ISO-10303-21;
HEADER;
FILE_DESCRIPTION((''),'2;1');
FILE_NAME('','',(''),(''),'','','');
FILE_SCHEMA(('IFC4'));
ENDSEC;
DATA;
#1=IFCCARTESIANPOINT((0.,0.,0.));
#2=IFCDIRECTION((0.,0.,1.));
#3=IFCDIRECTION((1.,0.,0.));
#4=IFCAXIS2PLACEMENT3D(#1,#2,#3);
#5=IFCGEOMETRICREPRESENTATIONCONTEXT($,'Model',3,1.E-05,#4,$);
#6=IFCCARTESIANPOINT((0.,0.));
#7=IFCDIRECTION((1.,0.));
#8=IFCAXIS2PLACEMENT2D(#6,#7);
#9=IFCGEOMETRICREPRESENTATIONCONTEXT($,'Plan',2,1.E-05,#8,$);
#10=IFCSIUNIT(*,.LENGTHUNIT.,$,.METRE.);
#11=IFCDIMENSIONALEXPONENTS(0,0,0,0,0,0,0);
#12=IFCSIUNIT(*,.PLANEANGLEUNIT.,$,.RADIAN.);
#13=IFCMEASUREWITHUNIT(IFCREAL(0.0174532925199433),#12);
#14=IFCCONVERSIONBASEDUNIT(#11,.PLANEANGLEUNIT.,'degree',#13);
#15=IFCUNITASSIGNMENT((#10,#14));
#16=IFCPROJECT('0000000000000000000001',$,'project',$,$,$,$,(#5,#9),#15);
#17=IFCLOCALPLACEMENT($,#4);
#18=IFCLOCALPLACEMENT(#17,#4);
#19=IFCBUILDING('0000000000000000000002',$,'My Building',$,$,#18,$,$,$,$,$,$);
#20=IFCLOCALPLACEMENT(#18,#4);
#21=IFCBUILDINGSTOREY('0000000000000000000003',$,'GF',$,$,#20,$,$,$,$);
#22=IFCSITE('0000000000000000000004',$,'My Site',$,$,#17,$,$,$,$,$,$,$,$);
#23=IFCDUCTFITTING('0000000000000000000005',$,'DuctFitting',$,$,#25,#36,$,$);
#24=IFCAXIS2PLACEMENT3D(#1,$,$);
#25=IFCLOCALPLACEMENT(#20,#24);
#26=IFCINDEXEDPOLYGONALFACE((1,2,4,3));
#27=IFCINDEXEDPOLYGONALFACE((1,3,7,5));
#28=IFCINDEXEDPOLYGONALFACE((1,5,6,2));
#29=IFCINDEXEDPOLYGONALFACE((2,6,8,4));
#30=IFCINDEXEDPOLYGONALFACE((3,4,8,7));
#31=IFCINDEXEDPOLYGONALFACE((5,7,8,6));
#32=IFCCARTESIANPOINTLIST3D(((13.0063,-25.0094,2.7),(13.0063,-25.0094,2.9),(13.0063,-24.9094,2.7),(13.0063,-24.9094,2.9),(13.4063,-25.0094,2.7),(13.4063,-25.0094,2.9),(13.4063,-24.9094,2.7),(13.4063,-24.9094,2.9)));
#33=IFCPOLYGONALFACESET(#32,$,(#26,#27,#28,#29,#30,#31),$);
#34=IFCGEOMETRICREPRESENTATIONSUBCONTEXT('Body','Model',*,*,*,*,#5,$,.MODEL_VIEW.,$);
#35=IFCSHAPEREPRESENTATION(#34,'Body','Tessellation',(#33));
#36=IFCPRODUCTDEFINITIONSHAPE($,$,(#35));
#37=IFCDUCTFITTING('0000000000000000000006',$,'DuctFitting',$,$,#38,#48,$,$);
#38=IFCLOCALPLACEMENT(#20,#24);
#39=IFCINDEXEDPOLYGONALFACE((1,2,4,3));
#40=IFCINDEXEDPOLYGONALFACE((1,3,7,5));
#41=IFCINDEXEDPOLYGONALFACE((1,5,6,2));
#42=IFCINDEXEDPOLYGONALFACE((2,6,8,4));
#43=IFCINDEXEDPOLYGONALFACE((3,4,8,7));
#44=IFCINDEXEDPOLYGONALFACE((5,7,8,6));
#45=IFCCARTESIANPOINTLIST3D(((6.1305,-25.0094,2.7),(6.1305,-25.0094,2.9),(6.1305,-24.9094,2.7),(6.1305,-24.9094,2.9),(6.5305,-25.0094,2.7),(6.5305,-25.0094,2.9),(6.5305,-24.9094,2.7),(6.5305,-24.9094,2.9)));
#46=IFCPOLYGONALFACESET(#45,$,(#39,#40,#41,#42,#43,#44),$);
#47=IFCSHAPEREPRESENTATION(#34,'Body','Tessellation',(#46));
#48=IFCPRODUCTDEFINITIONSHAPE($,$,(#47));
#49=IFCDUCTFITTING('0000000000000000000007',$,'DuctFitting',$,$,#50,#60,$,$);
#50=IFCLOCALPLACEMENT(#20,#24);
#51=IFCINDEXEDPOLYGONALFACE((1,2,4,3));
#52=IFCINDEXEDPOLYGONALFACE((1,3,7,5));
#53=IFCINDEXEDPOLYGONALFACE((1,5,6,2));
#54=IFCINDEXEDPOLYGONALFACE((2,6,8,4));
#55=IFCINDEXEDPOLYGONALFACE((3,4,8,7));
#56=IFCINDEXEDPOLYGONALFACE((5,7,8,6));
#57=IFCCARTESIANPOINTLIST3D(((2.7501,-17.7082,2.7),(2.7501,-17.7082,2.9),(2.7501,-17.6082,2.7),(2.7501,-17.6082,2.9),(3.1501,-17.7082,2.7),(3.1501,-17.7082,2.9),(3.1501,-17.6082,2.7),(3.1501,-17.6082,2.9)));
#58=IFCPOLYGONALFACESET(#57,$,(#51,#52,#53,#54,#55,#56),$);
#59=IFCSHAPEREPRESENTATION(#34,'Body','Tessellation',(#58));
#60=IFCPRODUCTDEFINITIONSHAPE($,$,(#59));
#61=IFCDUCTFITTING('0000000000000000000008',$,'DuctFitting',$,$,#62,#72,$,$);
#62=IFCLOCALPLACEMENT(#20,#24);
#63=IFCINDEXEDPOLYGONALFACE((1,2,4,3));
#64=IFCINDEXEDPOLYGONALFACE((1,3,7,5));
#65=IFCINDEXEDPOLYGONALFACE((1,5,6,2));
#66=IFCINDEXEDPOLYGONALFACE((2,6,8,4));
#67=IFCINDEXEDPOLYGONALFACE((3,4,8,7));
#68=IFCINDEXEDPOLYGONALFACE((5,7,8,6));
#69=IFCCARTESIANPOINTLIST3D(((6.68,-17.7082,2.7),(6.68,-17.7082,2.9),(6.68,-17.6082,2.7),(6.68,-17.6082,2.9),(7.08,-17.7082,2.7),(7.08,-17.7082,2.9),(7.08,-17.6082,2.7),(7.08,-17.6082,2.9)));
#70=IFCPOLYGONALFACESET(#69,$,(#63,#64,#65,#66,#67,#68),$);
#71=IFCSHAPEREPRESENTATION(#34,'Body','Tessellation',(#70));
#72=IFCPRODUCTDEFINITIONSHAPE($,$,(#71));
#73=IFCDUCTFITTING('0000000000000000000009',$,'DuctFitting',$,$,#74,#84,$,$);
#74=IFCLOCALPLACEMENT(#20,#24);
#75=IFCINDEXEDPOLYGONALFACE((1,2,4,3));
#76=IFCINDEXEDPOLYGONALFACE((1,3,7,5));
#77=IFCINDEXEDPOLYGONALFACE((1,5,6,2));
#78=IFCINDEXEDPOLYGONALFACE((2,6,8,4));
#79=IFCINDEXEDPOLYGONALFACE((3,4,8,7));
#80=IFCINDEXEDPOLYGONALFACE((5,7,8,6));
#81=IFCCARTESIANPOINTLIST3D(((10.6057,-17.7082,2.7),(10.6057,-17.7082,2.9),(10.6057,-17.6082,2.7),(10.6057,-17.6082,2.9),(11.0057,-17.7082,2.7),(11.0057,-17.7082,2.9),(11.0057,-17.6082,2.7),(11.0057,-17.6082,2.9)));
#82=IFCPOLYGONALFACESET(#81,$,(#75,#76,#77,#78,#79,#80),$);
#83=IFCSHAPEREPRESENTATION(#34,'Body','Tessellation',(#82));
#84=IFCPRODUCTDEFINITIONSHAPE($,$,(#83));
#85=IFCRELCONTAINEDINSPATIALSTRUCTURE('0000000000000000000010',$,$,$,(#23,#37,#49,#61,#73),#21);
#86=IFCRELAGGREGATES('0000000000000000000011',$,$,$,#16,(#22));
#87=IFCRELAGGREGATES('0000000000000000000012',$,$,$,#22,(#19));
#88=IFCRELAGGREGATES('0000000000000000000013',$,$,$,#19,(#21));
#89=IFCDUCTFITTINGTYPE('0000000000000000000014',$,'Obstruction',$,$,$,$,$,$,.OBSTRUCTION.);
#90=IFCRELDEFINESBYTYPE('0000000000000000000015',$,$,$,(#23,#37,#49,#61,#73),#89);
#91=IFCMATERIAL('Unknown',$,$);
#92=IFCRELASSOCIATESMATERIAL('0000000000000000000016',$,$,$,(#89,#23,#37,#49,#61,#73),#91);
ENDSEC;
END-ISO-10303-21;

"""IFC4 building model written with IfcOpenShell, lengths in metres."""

from ifc_helpers import new_model, entity, si_unit, converted_unit, frame, origin_with_axes, origin_2d_with_axis, place, context, subcontext, project, spatial, rectangle, extrude, material, material_profile, profile_set, profile_usage, type_object, element, save


model = new_model("IFC4")

# Units and contexts
model_context = context("Model", 3, precision=1e-05, world=origin_with_axes())
plan_context = context("Plan", 2, precision=1e-05, world=origin_2d_with_axis())
body_context_1 = subcontext(model_context, "Body", "Model", "MODEL_VIEW")
ifc_project = project(units=[si_unit("LENGTHUNIT", "METRE"), converted_unit("PLANEANGLEUNIT", "degree", entity("IfcReal", 0.0174532925199433), si_unit("PLANEANGLEUNIT", "RADIAN"), dimensions=[0, 0, 0, 0, 0, 0, 0])], contexts=[model_context, plan_context])

# Site, building, storey
site_placement = place(None, origin_with_axes())
site = spatial("IfcSite", under=ifc_project, at=site_placement, Name="My Site")
building_placement = place(site_placement, origin_with_axes())
building = spatial("IfcBuilding", under=site, at=building_placement, Name="My Building")
storey_placement = place(building_placement, origin_with_axes())
storey = spatial("IfcBuildingStorey", under=building, at=storey_placement, Name="GF")

# Shared definitions
ifc_material = material(Name="Unknown")

# Duct fittings
ifc_material_profile = material_profile(ifc_material, rectangle(XDim=0.4, YDim=0.2))
ifc_profile_set = profile_set([ifc_material_profile])
duct_fitting_type = type_object("IfcDuctFittingType", Name="Obstruction", PredefinedType="OBSTRUCTION", material=ifc_profile_set)
ifc_profile_usage_1 = profile_usage(ifc_profile_set, cardinal=5)
duct_fitting_1_placement = place(storey_placement, frame((13.2063, -25.0094, 2.8), z_axis=(0.0, 1.0, 0.0), x_axis=(-1.0, 0.0, 0.0)))
element("IfcDuctFitting", 1, at=duct_fitting_1_placement, inside=storey, type_object=duct_fitting_type, material=ifc_profile_usage_1, Name="DuctFitting", context=body_context_1, shape_type="SweptSolid", body=[
    extrude(rectangle(XDim=0.4, YDim=0.2), origin_with_axes(), (0.0, 0.0, 1.0), 0.1),
])
ifc_profile_usage_2 = profile_usage(ifc_profile_set, cardinal=5)
duct_fitting_2_placement = place(storey_placement, frame((6.3305, -24.9094, 2.8), z_axis=(0.0, -1.0, 0.0), x_axis=(1.0, 0.0, 0.0)))
element("IfcDuctFitting", 2, at=duct_fitting_2_placement, inside=storey, type_object=duct_fitting_type, material=ifc_profile_usage_2, Name="DuctFitting", context=body_context_1, shape_type="SweptSolid", body=[
    extrude(rectangle(XDim=0.4, YDim=0.2), origin_with_axes(), (0.0, 0.0, 1.0), 0.1),
])
ifc_profile_usage_3 = profile_usage(ifc_profile_set, cardinal=5)
duct_fitting_3_placement = place(storey_placement, frame((2.9501, -17.6082, 2.8), z_axis=(0.0, -1.0, 0.0), x_axis=(1.0, 0.0, 0.0)))
element("IfcDuctFitting", 3, at=duct_fitting_3_placement, inside=storey, type_object=duct_fitting_type, material=ifc_profile_usage_3, Name="DuctFitting", context=body_context_1, shape_type="SweptSolid", body=[
    extrude(rectangle(XDim=0.4, YDim=0.2), origin_with_axes(), (0.0, 0.0, 1.0), 0.1),
])
ifc_profile_usage_4 = profile_usage(ifc_profile_set, cardinal=5)
duct_fitting_4_placement = place(storey_placement, frame((6.88, -17.6082, 2.8), z_axis=(0.0, -1.0, 0.0), x_axis=(1.0, 0.0, 0.0)))
element("IfcDuctFitting", 4, at=duct_fitting_4_placement, inside=storey, type_object=duct_fitting_type, material=ifc_profile_usage_4, Name="DuctFitting", context=body_context_1, shape_type="SweptSolid", body=[
    extrude(rectangle(XDim=0.4, YDim=0.2), origin_with_axes(), (0.0, 0.0, 1.0), 0.1),
])
ifc_profile_usage_5 = profile_usage(ifc_profile_set, cardinal=5)
duct_fitting_5_placement = place(storey_placement, frame((10.8057, -17.6082, 2.8), z_axis=(0.0, -1.0, 0.0), x_axis=(1.0, 0.0, 0.0)))
element("IfcDuctFitting", 5, at=duct_fitting_5_placement, inside=storey, type_object=duct_fitting_type, material=ifc_profile_usage_5, Name="DuctFitting", context=body_context_1, shape_type="SweptSolid", body=[
    extrude(rectangle(XDim=0.4, YDim=0.2), origin_with_axes(), (0.0, 0.0, 1.0), 0.1),
])

save(model, "model.ifc")
